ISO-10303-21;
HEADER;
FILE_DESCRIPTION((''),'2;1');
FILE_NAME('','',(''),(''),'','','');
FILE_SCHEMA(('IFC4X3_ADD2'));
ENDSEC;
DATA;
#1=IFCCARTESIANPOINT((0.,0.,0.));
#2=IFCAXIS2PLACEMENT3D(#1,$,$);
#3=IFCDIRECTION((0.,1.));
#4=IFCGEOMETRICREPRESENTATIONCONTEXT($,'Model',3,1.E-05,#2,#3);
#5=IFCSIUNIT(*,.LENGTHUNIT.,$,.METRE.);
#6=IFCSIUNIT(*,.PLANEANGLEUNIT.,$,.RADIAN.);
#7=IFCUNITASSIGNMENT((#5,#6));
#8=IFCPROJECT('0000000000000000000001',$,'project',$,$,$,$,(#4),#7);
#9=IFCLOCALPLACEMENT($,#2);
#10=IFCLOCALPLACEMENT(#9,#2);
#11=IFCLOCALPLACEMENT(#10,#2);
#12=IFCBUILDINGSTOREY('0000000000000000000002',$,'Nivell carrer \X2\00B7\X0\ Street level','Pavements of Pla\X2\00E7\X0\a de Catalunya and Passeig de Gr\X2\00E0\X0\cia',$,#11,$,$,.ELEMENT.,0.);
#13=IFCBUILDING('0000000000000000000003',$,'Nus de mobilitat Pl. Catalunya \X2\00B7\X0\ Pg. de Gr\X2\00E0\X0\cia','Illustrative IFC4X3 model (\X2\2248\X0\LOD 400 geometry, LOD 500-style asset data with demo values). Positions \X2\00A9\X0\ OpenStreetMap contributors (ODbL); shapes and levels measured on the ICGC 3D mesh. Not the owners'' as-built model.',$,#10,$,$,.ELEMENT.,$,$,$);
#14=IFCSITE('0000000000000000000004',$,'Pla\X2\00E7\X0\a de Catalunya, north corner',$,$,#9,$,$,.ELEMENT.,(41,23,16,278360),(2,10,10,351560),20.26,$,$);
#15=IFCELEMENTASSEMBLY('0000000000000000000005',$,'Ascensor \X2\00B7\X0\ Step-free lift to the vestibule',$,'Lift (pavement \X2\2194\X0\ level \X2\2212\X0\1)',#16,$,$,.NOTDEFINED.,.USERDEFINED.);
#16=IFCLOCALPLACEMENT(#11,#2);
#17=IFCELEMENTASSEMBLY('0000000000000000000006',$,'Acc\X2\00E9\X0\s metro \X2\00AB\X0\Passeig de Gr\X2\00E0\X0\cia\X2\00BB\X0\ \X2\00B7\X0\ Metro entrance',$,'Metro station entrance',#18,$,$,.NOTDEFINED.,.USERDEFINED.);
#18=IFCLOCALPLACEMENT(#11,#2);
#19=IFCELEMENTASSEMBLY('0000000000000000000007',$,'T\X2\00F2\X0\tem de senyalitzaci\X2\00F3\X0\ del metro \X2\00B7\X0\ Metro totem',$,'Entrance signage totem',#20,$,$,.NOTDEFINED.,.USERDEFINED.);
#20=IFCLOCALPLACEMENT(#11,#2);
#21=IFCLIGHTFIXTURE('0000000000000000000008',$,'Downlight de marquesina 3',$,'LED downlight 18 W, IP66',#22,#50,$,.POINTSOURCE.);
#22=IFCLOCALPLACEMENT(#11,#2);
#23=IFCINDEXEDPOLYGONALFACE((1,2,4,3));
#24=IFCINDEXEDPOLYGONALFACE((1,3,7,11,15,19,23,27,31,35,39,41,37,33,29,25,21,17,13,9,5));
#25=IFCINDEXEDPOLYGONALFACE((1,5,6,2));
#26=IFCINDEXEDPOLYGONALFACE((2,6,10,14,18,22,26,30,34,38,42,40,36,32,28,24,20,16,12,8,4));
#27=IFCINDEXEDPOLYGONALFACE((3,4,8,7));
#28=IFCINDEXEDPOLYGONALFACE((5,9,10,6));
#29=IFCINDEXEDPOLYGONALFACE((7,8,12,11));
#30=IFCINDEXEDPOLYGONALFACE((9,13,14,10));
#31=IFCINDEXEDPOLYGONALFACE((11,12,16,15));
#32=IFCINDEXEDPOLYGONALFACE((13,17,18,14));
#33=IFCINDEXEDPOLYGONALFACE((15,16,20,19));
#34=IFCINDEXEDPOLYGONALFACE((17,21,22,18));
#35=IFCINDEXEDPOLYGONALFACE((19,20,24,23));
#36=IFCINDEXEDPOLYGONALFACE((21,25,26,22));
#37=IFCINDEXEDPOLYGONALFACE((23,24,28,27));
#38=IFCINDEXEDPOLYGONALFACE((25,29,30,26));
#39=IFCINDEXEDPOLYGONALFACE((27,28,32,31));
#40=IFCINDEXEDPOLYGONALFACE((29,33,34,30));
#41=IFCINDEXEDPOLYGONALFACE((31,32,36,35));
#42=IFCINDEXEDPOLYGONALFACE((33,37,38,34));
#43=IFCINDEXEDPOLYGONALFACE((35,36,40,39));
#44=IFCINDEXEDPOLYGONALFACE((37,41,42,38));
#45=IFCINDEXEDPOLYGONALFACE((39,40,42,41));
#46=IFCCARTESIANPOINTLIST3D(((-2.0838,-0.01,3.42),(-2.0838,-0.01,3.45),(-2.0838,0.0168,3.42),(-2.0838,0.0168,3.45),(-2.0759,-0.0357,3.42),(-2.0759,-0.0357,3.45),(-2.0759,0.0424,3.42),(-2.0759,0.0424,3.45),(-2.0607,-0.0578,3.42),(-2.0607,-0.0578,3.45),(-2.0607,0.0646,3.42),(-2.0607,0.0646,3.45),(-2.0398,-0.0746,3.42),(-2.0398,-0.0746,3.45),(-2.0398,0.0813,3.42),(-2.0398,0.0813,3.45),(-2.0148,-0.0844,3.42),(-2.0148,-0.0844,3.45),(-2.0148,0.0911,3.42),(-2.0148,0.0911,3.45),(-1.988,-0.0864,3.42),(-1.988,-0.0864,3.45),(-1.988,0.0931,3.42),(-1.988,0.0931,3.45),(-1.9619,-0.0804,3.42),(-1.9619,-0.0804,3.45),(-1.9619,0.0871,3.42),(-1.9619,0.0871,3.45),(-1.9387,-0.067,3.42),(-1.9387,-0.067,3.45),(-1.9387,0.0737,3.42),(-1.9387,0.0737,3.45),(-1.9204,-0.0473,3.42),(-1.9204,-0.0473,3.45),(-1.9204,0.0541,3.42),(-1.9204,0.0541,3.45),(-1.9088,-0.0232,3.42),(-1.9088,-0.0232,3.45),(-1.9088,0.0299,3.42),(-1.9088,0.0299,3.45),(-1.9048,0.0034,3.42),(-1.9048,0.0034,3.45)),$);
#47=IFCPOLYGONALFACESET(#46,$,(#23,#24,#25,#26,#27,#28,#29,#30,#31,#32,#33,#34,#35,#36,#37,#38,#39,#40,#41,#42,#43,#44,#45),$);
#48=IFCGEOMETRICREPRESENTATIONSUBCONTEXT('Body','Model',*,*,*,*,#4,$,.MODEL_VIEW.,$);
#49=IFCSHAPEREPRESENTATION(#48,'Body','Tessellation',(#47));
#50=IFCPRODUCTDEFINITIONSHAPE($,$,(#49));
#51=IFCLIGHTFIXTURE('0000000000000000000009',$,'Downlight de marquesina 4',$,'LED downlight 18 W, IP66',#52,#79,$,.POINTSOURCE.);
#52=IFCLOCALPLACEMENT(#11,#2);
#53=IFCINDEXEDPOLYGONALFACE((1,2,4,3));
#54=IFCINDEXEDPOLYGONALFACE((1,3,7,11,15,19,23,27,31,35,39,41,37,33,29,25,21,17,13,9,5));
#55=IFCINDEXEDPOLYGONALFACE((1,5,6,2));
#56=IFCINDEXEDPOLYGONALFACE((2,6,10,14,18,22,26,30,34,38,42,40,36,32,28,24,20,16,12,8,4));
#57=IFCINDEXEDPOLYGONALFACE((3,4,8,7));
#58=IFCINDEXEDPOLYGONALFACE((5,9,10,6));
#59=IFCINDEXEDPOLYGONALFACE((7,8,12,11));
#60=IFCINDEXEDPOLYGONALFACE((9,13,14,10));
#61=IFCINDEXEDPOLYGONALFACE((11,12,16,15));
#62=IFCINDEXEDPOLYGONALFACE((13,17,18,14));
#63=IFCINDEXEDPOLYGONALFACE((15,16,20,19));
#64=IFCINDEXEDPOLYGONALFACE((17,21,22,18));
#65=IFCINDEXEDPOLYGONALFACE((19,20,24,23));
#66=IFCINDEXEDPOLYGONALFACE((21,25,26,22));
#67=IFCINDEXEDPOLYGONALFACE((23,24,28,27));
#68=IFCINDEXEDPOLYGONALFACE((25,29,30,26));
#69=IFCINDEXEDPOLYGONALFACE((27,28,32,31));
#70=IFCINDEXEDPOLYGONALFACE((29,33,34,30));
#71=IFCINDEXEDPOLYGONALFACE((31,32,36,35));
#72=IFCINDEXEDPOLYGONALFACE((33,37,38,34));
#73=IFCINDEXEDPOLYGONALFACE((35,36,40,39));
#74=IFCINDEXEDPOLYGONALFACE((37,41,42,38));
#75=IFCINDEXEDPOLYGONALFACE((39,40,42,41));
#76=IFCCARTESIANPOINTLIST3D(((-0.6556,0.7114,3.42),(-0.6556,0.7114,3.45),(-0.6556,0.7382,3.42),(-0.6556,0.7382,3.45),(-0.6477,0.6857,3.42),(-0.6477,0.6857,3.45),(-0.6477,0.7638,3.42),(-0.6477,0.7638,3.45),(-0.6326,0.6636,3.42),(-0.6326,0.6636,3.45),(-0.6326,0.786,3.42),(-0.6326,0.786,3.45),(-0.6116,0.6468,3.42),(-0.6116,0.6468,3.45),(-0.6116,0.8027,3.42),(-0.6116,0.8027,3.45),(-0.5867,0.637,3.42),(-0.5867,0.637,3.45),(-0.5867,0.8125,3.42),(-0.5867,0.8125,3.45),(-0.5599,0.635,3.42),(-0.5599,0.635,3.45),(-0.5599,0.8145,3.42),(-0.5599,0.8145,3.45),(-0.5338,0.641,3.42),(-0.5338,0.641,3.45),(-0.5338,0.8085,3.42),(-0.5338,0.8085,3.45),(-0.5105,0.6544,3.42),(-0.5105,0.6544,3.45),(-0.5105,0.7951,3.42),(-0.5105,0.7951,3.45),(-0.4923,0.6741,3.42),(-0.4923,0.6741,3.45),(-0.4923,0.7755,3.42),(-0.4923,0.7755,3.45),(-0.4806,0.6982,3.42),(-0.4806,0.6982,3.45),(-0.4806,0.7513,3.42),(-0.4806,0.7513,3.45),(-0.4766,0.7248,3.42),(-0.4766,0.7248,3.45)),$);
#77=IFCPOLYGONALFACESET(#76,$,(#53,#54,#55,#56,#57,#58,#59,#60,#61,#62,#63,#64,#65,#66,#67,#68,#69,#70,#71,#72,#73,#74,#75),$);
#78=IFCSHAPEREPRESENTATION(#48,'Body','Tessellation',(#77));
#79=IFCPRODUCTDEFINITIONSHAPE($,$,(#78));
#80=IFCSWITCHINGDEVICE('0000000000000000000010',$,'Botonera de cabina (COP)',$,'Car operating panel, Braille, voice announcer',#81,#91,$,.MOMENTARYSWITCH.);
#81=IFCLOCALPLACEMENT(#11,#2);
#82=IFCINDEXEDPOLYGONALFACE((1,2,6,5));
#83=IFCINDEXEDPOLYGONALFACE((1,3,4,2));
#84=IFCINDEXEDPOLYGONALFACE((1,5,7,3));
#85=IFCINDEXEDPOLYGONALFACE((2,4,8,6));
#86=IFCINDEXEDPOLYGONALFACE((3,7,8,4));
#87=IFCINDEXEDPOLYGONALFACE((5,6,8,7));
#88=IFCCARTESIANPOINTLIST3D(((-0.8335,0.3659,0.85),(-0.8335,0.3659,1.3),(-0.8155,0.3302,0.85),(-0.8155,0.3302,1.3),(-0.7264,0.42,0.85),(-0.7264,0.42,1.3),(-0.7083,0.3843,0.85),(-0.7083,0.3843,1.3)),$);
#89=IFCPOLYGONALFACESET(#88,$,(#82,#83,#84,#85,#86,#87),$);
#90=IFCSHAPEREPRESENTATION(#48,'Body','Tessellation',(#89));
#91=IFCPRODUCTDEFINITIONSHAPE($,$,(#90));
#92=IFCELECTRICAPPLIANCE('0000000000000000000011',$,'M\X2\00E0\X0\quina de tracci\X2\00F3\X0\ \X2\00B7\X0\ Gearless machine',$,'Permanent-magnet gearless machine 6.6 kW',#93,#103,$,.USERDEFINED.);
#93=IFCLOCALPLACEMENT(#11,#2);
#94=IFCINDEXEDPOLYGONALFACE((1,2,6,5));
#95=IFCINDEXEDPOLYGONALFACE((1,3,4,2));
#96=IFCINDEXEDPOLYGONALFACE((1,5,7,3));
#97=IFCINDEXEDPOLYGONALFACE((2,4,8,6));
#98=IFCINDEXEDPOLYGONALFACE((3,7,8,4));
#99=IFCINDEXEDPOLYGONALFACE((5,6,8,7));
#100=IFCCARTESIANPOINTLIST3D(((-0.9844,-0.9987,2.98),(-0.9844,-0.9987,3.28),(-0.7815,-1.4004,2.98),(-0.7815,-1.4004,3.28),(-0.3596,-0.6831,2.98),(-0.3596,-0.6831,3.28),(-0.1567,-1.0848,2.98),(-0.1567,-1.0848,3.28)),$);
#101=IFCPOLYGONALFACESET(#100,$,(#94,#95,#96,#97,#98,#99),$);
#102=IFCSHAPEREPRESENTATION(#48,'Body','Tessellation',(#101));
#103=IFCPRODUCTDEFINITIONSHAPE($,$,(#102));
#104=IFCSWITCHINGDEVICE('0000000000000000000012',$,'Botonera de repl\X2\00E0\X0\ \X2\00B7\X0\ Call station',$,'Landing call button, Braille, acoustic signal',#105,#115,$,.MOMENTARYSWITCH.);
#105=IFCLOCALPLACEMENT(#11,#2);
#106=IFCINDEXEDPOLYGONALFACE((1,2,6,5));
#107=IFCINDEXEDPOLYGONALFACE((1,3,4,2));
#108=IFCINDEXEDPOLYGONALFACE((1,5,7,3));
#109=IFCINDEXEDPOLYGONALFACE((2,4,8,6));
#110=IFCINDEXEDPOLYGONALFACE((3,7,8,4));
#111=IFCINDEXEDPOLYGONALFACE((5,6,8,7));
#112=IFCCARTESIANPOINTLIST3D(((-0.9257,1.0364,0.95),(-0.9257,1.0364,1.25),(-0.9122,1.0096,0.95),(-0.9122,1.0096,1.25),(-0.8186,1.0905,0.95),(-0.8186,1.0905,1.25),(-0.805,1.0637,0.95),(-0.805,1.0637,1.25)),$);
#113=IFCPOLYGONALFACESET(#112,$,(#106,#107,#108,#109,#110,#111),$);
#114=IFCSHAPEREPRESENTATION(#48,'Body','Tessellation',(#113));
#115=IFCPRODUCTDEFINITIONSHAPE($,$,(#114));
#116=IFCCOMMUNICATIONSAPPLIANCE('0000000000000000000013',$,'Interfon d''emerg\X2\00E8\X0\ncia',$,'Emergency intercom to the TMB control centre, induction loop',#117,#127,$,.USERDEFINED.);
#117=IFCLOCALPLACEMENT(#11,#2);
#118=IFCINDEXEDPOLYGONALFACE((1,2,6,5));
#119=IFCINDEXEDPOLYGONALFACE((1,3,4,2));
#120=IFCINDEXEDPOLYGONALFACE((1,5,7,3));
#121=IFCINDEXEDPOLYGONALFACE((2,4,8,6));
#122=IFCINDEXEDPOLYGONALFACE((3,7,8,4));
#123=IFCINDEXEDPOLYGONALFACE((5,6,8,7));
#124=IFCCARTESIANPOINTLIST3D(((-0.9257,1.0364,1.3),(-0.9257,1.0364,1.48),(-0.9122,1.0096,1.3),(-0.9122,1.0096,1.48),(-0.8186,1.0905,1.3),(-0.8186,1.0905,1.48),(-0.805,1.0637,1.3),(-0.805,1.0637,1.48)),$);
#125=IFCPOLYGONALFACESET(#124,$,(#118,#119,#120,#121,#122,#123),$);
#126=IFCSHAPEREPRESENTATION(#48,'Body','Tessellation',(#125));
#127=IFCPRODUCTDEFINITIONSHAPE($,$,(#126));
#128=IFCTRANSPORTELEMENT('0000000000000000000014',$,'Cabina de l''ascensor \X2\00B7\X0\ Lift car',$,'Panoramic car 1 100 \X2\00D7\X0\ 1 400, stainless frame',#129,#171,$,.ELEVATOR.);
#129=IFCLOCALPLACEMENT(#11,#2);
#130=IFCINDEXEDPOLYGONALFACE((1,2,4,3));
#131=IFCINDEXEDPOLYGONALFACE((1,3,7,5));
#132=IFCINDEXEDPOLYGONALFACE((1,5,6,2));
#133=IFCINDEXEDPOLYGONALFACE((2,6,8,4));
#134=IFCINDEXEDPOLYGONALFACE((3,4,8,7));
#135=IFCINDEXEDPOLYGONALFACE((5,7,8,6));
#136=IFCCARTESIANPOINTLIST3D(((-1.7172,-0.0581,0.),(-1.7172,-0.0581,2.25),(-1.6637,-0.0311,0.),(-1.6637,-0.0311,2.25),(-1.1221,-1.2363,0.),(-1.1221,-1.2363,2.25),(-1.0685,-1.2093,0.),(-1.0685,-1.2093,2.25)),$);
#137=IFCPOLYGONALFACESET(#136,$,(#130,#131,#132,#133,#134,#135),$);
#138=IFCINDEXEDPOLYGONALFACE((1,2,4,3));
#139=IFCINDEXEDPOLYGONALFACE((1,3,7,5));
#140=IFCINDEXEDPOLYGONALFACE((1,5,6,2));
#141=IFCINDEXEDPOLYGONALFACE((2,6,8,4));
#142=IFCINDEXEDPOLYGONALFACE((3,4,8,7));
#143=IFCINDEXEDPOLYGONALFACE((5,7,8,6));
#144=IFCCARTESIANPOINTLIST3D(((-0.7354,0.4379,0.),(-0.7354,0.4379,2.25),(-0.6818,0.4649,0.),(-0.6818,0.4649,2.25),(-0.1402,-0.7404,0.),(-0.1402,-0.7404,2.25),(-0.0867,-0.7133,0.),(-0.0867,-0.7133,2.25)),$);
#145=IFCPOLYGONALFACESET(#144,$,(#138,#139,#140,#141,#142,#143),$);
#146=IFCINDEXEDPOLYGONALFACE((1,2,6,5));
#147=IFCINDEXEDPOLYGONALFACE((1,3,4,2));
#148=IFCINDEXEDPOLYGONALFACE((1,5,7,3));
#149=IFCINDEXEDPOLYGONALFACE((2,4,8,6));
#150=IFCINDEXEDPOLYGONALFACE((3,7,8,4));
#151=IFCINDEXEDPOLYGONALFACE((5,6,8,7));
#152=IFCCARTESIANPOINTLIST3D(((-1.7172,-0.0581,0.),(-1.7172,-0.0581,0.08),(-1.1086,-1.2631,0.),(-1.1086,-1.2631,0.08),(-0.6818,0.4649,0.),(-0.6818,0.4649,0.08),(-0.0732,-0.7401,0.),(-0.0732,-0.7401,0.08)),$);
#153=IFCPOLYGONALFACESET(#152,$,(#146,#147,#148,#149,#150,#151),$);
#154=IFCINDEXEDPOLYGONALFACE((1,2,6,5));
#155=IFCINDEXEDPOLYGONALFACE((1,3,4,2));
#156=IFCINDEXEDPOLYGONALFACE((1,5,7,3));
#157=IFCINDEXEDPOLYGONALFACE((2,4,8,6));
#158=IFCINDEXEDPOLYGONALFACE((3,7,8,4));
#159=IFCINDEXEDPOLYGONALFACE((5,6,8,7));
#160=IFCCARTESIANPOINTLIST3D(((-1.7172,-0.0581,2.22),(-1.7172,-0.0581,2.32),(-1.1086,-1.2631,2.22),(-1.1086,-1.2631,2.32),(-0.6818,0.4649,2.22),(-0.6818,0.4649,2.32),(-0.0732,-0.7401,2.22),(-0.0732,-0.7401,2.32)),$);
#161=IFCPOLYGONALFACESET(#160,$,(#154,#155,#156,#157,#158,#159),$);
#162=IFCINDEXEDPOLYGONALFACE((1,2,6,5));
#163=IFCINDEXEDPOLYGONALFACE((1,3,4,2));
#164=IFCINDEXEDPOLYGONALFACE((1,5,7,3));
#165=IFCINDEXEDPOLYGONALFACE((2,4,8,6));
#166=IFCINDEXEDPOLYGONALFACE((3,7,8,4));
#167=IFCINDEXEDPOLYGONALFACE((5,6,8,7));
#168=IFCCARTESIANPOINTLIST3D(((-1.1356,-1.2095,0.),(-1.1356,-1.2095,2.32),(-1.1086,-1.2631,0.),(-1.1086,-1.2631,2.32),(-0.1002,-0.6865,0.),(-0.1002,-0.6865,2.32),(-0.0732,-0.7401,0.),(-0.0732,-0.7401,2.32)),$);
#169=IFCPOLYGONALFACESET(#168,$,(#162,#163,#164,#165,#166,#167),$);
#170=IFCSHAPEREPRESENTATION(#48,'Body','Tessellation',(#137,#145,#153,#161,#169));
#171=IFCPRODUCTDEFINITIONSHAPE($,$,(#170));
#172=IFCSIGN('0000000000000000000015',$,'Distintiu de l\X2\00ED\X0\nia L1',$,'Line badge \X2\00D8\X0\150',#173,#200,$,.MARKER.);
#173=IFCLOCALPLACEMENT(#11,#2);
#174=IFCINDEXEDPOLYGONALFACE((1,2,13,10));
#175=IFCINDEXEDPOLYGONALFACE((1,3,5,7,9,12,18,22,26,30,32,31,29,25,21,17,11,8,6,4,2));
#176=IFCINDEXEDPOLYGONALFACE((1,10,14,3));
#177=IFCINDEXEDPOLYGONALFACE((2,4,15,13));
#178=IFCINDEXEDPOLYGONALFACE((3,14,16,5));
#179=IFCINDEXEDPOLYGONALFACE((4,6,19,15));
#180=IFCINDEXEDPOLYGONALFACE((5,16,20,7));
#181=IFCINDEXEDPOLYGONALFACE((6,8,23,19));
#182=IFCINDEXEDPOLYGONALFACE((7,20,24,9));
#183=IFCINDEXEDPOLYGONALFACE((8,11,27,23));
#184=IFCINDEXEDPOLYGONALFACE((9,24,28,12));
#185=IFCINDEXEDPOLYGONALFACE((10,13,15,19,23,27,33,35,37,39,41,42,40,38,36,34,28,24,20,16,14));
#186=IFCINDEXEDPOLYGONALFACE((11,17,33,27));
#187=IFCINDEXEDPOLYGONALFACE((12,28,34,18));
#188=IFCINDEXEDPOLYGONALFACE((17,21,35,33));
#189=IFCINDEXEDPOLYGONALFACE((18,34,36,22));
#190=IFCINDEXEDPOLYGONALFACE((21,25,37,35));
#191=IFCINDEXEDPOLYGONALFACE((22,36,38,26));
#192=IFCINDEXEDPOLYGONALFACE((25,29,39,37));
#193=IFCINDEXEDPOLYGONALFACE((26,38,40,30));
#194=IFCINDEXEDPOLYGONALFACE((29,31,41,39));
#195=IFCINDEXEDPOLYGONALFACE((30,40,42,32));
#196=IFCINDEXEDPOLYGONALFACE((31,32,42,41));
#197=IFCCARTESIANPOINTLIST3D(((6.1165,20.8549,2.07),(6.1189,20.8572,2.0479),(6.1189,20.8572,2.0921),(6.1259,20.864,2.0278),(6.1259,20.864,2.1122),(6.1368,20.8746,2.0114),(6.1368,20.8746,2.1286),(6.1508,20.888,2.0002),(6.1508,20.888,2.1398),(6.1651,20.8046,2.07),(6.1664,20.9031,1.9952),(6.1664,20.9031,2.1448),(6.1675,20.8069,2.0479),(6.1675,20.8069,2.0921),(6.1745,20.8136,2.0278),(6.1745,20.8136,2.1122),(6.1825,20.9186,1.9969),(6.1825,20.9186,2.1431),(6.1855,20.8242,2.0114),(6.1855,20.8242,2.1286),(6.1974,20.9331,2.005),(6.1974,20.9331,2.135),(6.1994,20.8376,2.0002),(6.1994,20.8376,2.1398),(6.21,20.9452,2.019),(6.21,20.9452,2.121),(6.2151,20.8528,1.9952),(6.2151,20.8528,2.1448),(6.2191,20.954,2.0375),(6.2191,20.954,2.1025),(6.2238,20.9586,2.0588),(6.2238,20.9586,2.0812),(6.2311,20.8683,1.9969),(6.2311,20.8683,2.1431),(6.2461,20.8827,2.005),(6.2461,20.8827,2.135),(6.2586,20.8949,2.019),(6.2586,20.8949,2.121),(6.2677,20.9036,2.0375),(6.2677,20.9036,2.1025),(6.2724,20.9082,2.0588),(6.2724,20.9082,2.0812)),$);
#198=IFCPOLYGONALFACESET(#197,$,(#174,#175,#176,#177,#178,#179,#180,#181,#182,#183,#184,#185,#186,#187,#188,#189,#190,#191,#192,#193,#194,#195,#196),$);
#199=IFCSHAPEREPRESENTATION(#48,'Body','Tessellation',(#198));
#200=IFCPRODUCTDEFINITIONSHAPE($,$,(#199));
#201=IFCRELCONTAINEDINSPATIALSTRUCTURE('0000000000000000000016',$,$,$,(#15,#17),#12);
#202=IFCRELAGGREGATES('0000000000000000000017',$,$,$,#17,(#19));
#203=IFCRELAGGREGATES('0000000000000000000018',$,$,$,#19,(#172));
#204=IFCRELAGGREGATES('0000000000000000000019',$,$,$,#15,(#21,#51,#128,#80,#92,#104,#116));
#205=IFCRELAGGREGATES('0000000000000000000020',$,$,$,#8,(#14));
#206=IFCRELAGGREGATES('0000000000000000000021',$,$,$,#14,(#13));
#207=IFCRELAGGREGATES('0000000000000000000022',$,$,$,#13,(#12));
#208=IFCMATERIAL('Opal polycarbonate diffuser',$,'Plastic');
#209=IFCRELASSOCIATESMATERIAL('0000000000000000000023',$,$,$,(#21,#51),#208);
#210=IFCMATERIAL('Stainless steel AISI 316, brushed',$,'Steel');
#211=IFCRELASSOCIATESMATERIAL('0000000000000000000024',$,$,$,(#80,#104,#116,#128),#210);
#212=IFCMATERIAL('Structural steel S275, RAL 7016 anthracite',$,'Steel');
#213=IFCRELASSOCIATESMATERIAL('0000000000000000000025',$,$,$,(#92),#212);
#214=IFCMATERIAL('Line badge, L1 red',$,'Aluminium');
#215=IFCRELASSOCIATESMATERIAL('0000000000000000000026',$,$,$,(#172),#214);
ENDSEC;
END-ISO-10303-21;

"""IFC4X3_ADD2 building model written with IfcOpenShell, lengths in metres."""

from ifc_helpers import new_model, si_unit, direction, frame, frame_2d, origin, origin_2d_with_axis, place, context, subcontext, project, spatial, rectangle, circle, extrude, material, element, aggregate, save


model = new_model("IFC4X3_ADD2")

# Units and contexts
model_context = context("Model", 3, precision=1e-05, world=origin(), true_north=direction((0.0, 1.0)))
body_context = subcontext(model_context, "Body", "Model", "MODEL_VIEW")
ifc_project = project(units=[si_unit("LENGTHUNIT", "METRE"), si_unit("PLANEANGLEUNIT", "RADIAN")], contexts=[model_context])

# Site, building, storey
site_placement = place(None, origin())
site = spatial("IfcSite", under=ifc_project, at=site_placement, Name="Plaça de Catalunya, north corner", CompositionType="ELEMENT", RefLatitude=(41, 23, 16, 278360), RefLongitude=(2, 10, 10, 351560), RefElevation=20.26)
building_placement = place(site_placement, origin())
building = spatial("IfcBuilding", under=site, at=building_placement, Name="Nus de mobilitat Pl. Catalunya · Pg. de Gràcia", Description="Illustrative IFC4X3 model (≈LOD 400 geometry, LOD 500-style asset data with demo values). Positions © OpenStreetMap contributors (ODbL); shapes and levels measured on the ICGC 3D mesh. Not the owners' as-built model.", CompositionType="ELEMENT")
storey_placement = place(building_placement, origin())
storey = spatial("IfcBuildingStorey", under=building, at=storey_placement, Name="Nivell carrer · Street level", Description="Pavements of Plaça de Catalunya and Passeig de Gràcia", CompositionType="ELEMENT", Elevation=0.0)

# Element assembly
assembly_1_placement = place(building_placement, origin())
assembly_1 = element("IfcElementAssembly", 1, at=assembly_1_placement, inside=storey, Name="Ascensor · Step-free lift to the vestibule", ObjectType="Lift (pavement ↔ level −1)", AssemblyPlace="NOTDEFINED", PredefinedType="USERDEFINED")
ifc_material_1 = material(Name="Structural steel S275, RAL 7016 anthracite", Category="Steel")

# Element assemblies
assembly_2_placement = place(building_placement, origin())
assembly_2 = element("IfcElementAssembly", 2, at=assembly_2_placement, inside=storey, Name="Accés metro «Passeig de Gràcia» · Metro entrance", ObjectType="Metro station entrance", AssemblyPlace="NOTDEFINED", PredefinedType="USERDEFINED")
ifc_material_2 = material(Name="Stainless steel AISI 316, brushed", Category="Steel")
assembly_3_placement = place(building_placement, origin())
assembly_3 = element("IfcElementAssembly", 3, at=assembly_3_placement, Name="Tòtem de senyalització del metro · Metro totem", ObjectType="Entrance signage totem", AssemblyPlace="NOTDEFINED", PredefinedType="USERDEFINED")

aggregate(assembly_2, [assembly_3])

# Light fixtures
ifc_material_3 = material(Name="Opal polycarbonate diffuser", Category="Plastic")
light_fixture_1_placement = place(building_placement, origin())
light_fixture_1 = element("IfcLightFixture", 4, at=light_fixture_1_placement, material=ifc_material_3, Name="Downlight de marquesina 3", ObjectType="LED downlight 18 W, IP66", PredefinedType="POINTSOURCE", context=body_context, shape_type="SweptSolid", body=[
    extrude(circle(Radius=0.09, at=origin_2d_with_axis()), frame((-1.9948, 0.0034, 3.42)), (0.0, 0.0, 1.0), 0.03),
])
light_fixture_2_placement = place(building_placement, origin())
light_fixture_2 = element("IfcLightFixture", 5, at=light_fixture_2_placement, material=ifc_material_3, Name="Downlight de marquesina 4", ObjectType="LED downlight 18 W, IP66", PredefinedType="POINTSOURCE", context=body_context, shape_type="SweptSolid", body=[
    extrude(circle(Radius=0.09, at=origin_2d_with_axis()), frame((-0.5666, 0.7248, 3.42)), (0.0, 0.0, 1.0), 0.03),
])

# Switching device
switching_device_1_placement = place(building_placement, origin())
switching_device_1 = element("IfcSwitchingDevice", 6, at=switching_device_1_placement, material=ifc_material_2, Name="Botonera de cabina (COP)", ObjectType="Car operating panel, Braille, voice announcer", PredefinedType="MOMENTARYSWITCH", context=body_context, shape_type="SweptSolid", body=[
    extrude(rectangle(XDim=0.12, YDim=0.04, at=frame_2d((0.0, 0.0), x_axis=(0.892586, 0.450878))), frame((-0.7709, 0.3751, 0.85)), (0.0, 0.0, 1.0), 0.45),
])

# Electric appliance
electric_appliance_placement = place(building_placement, origin())
electric_appliance = element("IfcElectricAppliance", 7, at=electric_appliance_placement, material=ifc_material_1, Name="Màquina de tracció · Gearless machine", ObjectType="Permanent-magnet gearless machine 6.6 kW", PredefinedType="USERDEFINED", context=body_context, shape_type="SweptSolid", body=[
    extrude(rectangle(XDim=0.7, YDim=0.45, at=frame_2d((0.0, 0.0), x_axis=(0.892586, 0.450878))), frame((-0.5706, -1.0418, 2.98)), (0.0, 0.0, 1.0), 0.3),
])

# Switching device
switching_device_2_placement = place(building_placement, origin())
switching_device_2 = element("IfcSwitchingDevice", 8, at=switching_device_2_placement, material=ifc_material_2, Name="Botonera de replà · Call station", ObjectType="Landing call button, Braille, acoustic signal", PredefinedType="MOMENTARYSWITCH", context=body_context, shape_type="SweptSolid", body=[
    extrude(rectangle(XDim=0.12, YDim=0.03, at=frame_2d((0.0, 0.0), x_axis=(0.892586, 0.450878))), frame((-0.8654, 1.05, 0.95)), (0.0, 0.0, 1.0), 0.3),
])

# Communications appliance
communications_appliance_placement = place(building_placement, origin())
communications_appliance = element("IfcCommunicationsAppliance", 9, at=communications_appliance_placement, material=ifc_material_2, Name="Interfon d'emergència", ObjectType="Emergency intercom to the TMB control centre, induction loop", PredefinedType="USERDEFINED", context=body_context, shape_type="SweptSolid", body=[
    extrude(rectangle(XDim=0.12, YDim=0.03, at=frame_2d((0.0, 0.0), x_axis=(0.892586, 0.450878))), frame((-0.8654, 1.05, 1.3)), (0.0, 0.0, 1.0), 0.18),
])

# Transport element
transport_element_placement = place(building_placement, origin())
transport_element = element("IfcTransportElement", 10, at=transport_element_placement, material=ifc_material_2, Name="Cabina de l'ascensor · Lift car", ObjectType="Panoramic car 1 100 × 1 400, stainless frame", PredefinedType="ELEVATOR", context=body_context, shape_type="SweptSolid", body=[
    extrude(rectangle(XDim=0.06, YDim=1.32, at=frame_2d((0.0, 0.0), x_axis=(0.892586, 0.450878))), frame((-1.3929, -0.6337, 0.0)), (0.0, 0.0, 1.0), 2.25),
    extrude(rectangle(XDim=0.06, YDim=1.32, at=frame_2d((0.0, 0.0), x_axis=(0.892586, 0.450878))), frame((-0.411, -0.1377, 0.0)), (0.0, 0.0, 1.0), 2.25),
    extrude(rectangle(XDim=1.16, YDim=1.35, at=frame_2d((0.0, 0.0), x_axis=(0.892586, 0.450878))), frame((-0.8952, -0.3991, 0.0)), (0.0, 0.0, 1.0), 0.08),
    extrude(rectangle(XDim=1.16, YDim=1.35, at=frame_2d((0.0, 0.0), x_axis=(0.892586, 0.450878))), frame((-0.8952, -0.3991, 2.22)), (0.0, 0.0, 1.0), 0.1),
    extrude(rectangle(XDim=1.16, YDim=0.06, at=frame_2d((0.0, 0.0), x_axis=(0.892586, 0.450878))), frame((-0.6044, -0.9748, 0.0)), (0.0, 0.0, 1.0), 2.32),
])

# Sign
ifc_material_4 = material(Name="Line badge, L1 red", Category="Aluminium")
sign_1_placement = place(building_placement, origin())
sign_1 = element("IfcSign", 11, at=sign_1_placement, material=ifc_material_4, Name="Distintiu de línia L1", ObjectType="Line badge Ø150", PredefinedType="MARKER", context=body_context, shape_type="SweptSolid", body=[
    extrude(circle(Radius=0.075, at=origin_2d_with_axis()), frame((6.1705, 20.907, 2.07), z_axis=(0.694658, -0.71934, 0.0), x_axis=(-0.71934, -0.694658, 0.0)), (0.0, 0.0, 1.0), 0.07),
])
aggregate(assembly_3, [sign_1])
aggregate(assembly_1, [light_fixture_1, light_fixture_2, transport_element, switching_device_1, electric_appliance, switching_device_2, communications_appliance])

save(model, "model.ifc")
